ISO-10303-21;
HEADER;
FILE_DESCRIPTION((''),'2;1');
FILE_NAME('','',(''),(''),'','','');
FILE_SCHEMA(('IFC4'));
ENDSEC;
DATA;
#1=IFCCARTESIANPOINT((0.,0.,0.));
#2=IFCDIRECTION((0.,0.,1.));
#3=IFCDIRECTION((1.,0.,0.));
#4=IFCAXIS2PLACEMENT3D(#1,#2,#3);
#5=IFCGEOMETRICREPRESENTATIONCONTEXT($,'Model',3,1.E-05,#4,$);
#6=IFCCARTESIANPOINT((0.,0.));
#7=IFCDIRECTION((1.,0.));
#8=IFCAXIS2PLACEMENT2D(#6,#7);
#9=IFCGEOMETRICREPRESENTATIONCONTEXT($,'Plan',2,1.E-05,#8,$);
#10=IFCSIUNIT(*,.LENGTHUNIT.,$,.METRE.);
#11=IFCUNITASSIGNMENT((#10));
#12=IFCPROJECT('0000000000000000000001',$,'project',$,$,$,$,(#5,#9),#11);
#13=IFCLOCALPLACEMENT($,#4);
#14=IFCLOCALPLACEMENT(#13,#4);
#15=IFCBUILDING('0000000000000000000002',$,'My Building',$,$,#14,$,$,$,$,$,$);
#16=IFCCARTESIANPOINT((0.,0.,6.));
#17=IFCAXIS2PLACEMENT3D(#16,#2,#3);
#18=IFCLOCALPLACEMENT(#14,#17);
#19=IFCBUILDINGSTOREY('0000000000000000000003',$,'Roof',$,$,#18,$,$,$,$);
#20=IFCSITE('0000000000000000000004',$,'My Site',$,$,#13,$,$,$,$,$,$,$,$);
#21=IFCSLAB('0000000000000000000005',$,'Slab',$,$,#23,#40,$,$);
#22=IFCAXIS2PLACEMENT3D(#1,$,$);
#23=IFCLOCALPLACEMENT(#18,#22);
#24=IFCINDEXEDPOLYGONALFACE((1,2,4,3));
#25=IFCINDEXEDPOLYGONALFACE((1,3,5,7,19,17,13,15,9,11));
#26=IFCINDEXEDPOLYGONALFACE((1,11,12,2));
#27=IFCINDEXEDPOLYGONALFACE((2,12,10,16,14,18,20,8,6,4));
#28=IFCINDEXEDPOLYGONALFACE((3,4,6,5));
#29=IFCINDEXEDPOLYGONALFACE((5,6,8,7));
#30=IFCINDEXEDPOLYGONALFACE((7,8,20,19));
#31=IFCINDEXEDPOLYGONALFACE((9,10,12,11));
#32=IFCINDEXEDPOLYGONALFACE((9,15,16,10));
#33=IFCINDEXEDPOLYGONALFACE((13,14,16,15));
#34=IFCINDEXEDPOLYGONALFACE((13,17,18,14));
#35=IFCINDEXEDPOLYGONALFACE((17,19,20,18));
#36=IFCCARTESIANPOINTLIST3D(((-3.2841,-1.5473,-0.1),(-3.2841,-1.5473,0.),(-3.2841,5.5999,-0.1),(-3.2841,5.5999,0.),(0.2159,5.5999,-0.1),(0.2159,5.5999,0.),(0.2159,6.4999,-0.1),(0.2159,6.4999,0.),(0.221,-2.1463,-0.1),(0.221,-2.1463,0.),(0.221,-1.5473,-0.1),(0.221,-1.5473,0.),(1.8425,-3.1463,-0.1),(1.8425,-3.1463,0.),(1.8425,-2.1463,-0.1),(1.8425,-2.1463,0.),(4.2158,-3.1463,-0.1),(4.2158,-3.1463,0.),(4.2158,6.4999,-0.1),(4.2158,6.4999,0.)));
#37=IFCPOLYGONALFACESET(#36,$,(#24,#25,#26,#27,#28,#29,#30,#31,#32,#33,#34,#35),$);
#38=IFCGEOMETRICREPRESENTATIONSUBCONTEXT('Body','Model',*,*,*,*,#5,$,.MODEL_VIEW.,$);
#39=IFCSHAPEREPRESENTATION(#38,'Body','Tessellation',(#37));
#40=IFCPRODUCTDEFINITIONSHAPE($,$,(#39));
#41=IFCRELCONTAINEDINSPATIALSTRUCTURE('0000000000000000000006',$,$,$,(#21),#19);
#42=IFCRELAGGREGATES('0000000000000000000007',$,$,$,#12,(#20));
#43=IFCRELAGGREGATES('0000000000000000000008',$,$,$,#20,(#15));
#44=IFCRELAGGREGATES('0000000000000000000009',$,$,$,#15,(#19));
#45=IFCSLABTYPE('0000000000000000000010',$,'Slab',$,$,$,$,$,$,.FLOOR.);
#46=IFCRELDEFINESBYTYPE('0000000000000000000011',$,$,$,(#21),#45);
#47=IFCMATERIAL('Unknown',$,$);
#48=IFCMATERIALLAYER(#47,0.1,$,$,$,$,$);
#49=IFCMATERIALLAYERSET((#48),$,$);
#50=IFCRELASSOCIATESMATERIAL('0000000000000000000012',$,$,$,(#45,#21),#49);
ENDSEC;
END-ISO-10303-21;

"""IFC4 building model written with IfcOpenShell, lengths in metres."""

from ifc_helpers import new_model, si_unit, frame, origin_with_axes, origin_2d_with_axis, place, context, subcontext, project, spatial, indexed_curve, outline, extrude, material, layer, layer_set, layer_usage, type_object, element, save


model = new_model("IFC4")

# Units and contexts
model_context = context("Model", 3, precision=1e-05, world=origin_with_axes())
plan_context = context("Plan", 2, precision=1e-05, world=origin_2d_with_axis())
body_context = subcontext(model_context, "Body", "Model", "MODEL_VIEW")
ifc_project = project(units=[si_unit("LENGTHUNIT", "METRE")], contexts=[model_context, plan_context])

# Site, building, storey
site_placement = place(None, origin_with_axes())
site = spatial("IfcSite", under=ifc_project, at=site_placement, Name="My Site")
building_placement = place(site_placement, origin_with_axes())
building = spatial("IfcBuilding", under=site, at=building_placement, Name="My Building")
storey_placement = place(building_placement, frame((0.0, 0.0, 6.0), z_axis=(0.0, 0.0, 1.0), x_axis=(1.0, 0.0, 0.0)))
storey = spatial("IfcBuildingStorey", under=building, at=storey_placement, Name="Roof")

# Slab
ifc_material = material(Name="Unknown")
ifc_layer = layer(ifc_material, 0.1)
ifc_layer_set = layer_set([ifc_layer])
ifc_layer_usage = layer_usage(ifc_layer_set, "AXIS3", "POSITIVE", -0.1)
slab_type = type_object("IfcSlabType", Name="Slab", PredefinedType="FLOOR", material=ifc_layer_set)
slab_placement = place(storey_placement, frame((4.2158, 6.4999, 0.0), z_axis=(0.0, 0.0, 1.0), x_axis=(1.0, 0.0, 0.0)))
element("IfcSlab", 1, at=slab_placement, inside=storey, type_object=slab_type, material=ifc_layer_usage, Name="Slab", context=body_context, shape_type="SweptSolid", body=[
    extrude(outline(indexed_curve([(0.0, 0.0), (-4.0, 0.0), (-4.0, -0.9), (-7.5, -0.9), (-7.5, -8.0471), (-3.9948, -8.0471), (-3.9948, -8.6461), (-2.3734, -8.6461), (-2.3734, -9.6461), (0.0, -9.6461), (0.0, 0.0)])), frame((0.0, 0.0, -0.1), z_axis=(0.0, 0.0, 1.0), x_axis=(1.0, 0.0, 0.0)), (0.0, 0.0, 1.0), 0.1),
])

save(model, "model.ifc")
